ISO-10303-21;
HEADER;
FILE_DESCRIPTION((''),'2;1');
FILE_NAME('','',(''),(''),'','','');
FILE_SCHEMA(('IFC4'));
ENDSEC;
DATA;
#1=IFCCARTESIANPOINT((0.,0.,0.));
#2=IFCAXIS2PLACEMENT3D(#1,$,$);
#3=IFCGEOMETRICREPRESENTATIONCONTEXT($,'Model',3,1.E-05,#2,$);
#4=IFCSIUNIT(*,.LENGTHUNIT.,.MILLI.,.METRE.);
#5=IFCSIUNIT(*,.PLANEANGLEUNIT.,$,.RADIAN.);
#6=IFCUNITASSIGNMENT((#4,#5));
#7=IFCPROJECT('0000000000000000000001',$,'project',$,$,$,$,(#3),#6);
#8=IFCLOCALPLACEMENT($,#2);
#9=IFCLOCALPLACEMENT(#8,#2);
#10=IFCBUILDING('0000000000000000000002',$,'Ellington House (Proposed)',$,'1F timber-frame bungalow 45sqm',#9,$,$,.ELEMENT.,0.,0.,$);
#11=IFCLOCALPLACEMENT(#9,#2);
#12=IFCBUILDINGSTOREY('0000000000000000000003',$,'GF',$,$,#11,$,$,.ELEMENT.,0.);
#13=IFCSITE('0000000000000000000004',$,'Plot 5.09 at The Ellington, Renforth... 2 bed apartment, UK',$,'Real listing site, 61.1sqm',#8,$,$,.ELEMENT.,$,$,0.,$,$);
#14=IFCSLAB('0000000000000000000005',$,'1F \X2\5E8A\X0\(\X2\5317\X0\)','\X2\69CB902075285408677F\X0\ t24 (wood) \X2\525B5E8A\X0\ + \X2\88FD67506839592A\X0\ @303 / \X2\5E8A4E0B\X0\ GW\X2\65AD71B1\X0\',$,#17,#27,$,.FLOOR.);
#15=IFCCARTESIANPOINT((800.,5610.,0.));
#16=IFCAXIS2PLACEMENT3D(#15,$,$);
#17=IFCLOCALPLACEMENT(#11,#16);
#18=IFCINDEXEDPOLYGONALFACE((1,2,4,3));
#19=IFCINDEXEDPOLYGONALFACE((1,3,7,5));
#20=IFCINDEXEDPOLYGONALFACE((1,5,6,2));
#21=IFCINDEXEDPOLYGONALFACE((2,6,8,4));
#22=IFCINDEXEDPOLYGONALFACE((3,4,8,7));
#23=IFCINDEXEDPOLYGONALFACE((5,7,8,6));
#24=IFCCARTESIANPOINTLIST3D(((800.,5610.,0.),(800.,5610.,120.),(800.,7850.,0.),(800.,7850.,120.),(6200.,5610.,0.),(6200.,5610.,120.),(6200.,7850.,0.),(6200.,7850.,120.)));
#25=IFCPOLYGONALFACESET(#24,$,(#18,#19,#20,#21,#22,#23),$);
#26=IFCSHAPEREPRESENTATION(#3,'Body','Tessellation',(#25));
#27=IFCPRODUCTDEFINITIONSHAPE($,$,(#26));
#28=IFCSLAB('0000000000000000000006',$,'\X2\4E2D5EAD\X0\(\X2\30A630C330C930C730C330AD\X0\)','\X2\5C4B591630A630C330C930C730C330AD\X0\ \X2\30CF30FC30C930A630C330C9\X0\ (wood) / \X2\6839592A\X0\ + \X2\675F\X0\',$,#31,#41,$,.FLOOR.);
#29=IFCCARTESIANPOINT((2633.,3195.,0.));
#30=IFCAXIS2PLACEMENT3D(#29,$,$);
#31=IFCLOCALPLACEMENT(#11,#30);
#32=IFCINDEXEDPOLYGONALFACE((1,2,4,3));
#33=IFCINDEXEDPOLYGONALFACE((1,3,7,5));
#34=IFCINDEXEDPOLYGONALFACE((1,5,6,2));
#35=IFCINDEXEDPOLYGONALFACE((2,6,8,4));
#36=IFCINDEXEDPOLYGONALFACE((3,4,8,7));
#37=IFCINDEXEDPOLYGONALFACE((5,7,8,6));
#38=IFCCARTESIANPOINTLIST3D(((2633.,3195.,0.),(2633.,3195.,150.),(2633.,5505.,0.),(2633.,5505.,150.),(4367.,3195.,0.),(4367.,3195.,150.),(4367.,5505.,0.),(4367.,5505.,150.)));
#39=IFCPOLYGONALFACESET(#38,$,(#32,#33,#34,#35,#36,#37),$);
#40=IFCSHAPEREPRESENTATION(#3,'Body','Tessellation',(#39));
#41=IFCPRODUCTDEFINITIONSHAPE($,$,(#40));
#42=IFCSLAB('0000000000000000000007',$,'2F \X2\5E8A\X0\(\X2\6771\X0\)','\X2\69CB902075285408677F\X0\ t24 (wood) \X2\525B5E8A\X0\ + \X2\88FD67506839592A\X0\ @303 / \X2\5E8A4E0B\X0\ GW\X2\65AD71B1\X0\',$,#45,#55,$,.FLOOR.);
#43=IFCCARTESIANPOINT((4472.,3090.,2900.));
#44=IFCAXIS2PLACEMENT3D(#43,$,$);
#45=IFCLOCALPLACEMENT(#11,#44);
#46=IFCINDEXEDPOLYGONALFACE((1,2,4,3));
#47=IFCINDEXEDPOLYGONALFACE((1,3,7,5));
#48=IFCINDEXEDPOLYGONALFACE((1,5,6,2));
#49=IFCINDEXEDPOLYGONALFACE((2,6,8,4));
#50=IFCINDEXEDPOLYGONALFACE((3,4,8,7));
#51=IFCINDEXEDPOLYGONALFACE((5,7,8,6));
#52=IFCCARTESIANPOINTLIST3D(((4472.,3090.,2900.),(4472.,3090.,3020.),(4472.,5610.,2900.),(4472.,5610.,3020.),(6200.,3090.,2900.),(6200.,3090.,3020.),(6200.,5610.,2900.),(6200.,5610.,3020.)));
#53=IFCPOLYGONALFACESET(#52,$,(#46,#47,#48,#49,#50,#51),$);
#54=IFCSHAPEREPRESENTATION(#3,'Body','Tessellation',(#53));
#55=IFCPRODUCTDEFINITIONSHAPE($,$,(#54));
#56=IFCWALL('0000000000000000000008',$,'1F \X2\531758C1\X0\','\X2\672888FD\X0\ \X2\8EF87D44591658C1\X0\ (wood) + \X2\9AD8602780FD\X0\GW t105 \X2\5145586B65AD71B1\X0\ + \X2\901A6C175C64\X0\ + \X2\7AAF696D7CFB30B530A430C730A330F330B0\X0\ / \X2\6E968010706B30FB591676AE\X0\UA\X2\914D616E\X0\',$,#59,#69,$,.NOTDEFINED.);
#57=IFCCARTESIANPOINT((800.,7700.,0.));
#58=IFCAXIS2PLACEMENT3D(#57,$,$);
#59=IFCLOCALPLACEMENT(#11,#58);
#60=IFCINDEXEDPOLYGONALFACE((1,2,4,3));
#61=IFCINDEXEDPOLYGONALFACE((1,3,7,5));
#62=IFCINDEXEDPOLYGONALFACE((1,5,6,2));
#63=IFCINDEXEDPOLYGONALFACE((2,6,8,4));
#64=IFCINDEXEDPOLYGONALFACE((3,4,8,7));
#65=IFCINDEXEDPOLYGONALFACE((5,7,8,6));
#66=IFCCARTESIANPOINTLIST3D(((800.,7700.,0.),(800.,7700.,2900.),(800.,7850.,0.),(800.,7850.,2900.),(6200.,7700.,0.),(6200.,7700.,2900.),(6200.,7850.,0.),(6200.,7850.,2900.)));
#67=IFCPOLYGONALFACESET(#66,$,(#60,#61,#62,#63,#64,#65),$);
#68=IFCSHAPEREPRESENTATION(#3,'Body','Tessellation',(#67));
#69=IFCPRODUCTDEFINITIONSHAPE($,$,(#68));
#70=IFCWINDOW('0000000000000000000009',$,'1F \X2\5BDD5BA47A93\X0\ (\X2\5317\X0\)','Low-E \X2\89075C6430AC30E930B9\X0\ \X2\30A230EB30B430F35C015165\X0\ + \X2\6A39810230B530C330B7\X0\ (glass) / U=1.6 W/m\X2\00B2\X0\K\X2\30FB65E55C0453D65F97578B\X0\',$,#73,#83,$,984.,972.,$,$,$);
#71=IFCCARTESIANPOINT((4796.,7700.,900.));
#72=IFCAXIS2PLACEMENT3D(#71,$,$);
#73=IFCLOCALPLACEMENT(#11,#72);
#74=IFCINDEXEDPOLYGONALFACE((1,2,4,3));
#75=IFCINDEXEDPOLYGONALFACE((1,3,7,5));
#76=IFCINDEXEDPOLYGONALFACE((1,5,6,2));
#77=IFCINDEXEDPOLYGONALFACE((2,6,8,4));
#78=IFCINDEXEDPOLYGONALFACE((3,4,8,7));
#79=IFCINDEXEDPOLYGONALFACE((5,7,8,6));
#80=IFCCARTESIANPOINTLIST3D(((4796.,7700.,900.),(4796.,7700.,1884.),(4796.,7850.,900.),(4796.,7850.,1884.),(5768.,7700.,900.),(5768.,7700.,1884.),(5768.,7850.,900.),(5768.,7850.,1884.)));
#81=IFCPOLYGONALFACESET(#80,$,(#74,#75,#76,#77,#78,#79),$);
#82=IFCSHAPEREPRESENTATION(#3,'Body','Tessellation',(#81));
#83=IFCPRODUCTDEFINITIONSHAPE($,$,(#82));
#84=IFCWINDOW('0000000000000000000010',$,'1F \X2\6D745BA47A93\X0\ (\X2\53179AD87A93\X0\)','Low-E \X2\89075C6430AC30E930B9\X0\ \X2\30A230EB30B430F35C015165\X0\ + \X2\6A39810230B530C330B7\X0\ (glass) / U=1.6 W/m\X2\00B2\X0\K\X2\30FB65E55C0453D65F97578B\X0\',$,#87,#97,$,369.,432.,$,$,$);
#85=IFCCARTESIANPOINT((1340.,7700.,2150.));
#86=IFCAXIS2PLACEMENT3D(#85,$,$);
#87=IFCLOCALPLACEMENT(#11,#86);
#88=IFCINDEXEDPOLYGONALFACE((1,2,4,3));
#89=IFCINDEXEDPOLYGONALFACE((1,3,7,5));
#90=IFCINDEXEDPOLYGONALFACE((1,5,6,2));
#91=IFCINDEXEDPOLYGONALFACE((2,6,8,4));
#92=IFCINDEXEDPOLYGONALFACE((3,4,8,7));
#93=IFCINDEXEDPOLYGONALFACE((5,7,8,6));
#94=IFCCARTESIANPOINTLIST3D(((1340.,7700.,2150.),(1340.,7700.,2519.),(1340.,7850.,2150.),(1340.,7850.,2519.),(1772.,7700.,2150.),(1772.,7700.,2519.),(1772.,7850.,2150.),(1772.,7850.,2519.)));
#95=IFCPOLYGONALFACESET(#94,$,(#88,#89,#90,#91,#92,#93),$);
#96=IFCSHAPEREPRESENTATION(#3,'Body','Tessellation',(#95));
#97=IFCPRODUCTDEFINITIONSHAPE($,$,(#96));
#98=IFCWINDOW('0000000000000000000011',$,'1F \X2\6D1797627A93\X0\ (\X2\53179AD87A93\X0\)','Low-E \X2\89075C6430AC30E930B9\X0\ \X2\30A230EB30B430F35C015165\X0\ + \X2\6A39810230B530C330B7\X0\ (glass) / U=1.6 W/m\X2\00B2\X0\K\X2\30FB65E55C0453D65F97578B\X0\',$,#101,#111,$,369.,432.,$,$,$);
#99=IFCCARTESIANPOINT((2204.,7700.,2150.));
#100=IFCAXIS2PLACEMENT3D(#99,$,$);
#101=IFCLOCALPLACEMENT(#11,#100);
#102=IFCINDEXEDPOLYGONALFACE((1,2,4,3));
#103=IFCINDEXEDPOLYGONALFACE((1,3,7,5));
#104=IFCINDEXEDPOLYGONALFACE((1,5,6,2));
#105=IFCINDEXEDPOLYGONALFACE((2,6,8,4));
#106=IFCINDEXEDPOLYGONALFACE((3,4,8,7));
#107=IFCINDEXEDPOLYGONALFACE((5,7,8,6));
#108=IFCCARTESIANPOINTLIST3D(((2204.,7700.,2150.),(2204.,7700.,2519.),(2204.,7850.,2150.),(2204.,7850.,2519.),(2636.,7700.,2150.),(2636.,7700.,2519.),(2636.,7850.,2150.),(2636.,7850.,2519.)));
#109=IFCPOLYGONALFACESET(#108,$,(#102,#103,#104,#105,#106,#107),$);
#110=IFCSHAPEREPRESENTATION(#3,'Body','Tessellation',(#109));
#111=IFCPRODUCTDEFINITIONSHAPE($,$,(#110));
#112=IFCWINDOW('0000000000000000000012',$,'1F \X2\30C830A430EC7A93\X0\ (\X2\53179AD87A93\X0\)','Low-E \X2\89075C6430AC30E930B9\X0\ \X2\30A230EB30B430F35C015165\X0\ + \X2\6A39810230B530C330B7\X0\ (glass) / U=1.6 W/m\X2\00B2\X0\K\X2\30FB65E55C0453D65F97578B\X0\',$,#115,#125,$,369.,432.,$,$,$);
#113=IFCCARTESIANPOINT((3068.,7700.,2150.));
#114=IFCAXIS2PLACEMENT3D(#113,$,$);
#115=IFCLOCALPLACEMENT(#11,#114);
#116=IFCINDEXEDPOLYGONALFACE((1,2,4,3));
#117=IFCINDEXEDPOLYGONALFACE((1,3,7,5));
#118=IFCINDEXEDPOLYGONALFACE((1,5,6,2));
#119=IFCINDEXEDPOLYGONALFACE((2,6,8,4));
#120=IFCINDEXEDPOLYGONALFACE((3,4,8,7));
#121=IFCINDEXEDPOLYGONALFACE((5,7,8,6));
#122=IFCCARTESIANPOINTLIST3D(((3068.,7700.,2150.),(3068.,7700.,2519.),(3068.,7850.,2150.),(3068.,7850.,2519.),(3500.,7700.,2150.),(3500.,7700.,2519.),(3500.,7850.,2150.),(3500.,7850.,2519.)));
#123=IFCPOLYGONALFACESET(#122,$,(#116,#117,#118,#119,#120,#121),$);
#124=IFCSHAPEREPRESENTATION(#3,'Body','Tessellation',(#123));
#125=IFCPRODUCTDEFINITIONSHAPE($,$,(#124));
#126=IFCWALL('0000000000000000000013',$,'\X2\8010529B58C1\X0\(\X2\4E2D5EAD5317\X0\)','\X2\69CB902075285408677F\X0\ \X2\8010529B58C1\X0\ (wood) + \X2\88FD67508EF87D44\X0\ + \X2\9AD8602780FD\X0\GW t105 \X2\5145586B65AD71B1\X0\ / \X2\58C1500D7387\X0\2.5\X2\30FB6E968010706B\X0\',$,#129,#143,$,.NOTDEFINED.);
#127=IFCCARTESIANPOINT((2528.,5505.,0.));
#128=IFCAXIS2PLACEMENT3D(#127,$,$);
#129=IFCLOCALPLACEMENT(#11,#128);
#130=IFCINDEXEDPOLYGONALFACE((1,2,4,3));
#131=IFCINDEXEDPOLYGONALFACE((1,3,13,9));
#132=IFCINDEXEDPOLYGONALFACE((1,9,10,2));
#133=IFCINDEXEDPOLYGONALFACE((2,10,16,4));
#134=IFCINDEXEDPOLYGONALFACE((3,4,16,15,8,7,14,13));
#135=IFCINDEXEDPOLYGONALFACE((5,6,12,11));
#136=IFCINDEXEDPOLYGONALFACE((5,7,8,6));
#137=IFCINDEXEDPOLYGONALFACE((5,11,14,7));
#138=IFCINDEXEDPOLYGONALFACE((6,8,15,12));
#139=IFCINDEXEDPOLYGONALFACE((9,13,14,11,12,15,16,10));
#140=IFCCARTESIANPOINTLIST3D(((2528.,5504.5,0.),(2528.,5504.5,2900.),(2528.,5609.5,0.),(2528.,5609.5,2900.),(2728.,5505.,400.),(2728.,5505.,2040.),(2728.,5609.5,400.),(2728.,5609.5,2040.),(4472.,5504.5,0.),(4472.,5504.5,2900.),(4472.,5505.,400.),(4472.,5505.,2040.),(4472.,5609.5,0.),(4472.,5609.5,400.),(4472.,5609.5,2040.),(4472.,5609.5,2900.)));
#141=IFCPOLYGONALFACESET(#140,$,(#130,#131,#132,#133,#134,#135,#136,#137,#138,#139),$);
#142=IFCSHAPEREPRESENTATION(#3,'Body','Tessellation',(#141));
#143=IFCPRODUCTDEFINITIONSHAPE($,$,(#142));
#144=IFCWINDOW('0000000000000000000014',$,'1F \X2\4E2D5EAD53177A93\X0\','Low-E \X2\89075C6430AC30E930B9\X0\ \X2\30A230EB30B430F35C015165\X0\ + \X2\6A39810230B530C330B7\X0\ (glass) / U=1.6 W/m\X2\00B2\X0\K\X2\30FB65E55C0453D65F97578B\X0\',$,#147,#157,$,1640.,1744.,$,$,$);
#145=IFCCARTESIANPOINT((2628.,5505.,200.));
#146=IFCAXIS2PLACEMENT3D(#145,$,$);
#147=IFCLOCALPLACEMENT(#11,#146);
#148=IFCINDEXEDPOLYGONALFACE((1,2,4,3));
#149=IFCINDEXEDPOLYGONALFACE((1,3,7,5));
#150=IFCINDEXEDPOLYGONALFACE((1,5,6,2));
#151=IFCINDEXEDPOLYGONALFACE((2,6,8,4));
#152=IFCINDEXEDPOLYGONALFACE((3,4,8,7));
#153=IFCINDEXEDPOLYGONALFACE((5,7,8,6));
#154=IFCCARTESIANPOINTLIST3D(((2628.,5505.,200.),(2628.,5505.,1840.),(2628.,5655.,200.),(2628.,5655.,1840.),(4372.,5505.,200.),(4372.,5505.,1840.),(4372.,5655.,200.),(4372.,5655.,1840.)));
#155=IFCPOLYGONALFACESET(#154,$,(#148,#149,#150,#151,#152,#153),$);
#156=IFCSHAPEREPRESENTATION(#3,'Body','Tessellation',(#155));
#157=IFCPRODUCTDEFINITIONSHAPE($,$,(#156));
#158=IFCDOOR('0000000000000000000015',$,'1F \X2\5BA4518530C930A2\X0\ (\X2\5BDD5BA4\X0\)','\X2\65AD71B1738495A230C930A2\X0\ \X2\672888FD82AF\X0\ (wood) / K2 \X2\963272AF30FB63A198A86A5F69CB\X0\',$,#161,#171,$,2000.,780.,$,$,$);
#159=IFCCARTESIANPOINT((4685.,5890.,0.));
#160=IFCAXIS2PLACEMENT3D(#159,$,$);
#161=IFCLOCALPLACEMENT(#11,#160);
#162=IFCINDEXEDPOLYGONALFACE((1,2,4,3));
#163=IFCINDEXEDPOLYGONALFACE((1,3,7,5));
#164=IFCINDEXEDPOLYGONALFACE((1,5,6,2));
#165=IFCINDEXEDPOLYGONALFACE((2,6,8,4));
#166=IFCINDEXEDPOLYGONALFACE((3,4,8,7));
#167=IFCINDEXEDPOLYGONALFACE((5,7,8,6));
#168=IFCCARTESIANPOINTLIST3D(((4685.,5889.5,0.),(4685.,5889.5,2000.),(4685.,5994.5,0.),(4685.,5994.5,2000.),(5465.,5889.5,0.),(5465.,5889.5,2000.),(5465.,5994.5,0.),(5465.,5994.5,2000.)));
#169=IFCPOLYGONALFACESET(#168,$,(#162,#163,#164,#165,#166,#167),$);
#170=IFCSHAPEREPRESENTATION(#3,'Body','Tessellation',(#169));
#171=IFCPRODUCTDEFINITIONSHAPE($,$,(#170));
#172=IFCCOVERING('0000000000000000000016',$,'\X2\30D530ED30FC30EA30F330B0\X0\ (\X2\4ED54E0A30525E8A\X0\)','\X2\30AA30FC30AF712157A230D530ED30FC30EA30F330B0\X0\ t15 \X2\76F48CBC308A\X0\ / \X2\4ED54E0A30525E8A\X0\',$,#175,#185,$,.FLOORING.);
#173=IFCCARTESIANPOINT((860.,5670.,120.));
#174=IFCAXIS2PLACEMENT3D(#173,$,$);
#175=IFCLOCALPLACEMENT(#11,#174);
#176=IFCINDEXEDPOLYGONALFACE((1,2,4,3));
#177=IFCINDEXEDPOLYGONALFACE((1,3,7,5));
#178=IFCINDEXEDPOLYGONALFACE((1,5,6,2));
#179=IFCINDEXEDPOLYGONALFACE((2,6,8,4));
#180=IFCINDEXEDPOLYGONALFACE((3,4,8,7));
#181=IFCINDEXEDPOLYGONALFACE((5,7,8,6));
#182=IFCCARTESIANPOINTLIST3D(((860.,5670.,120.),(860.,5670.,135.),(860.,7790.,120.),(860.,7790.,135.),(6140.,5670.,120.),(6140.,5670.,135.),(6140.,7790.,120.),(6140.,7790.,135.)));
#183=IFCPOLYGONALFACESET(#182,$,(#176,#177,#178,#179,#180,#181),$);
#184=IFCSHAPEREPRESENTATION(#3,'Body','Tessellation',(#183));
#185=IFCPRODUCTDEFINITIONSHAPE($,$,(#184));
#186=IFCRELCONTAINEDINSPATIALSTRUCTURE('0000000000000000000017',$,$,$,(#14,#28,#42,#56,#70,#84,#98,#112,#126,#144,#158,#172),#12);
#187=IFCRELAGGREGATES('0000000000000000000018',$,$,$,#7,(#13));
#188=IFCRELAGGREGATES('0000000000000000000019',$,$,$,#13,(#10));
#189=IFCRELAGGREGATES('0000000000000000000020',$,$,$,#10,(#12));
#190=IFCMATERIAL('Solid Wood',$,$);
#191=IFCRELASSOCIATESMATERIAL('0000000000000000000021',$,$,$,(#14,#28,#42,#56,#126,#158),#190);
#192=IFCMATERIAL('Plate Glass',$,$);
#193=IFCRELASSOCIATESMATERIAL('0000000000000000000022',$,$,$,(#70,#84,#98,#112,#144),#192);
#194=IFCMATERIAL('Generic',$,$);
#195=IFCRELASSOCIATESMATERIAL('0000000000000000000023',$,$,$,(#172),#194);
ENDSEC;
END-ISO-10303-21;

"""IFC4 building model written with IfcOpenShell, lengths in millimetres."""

from ifc_helpers import new_model, si_unit, frame, frame_2d, origin, place, context, project, spatial, rectangle, extrude, material, element, fill, save


model = new_model("IFC4")

# Units and contexts
model_context = context("Model", 3, precision=1e-05, world=origin())
ifc_project = project(units=[si_unit("LENGTHUNIT", "METRE", prefix="MILLI"), si_unit("PLANEANGLEUNIT", "RADIAN")], contexts=[model_context])

# Site, building, storey
site_placement = place(None, origin())
site = spatial("IfcSite", under=ifc_project, at=site_placement, Name="Plot 5.09 at The Ellington, Renforth... 2 bed apartment, UK", ObjectType="Real listing site, 61.1sqm", CompositionType="ELEMENT", RefElevation=0.0)
building_placement = place(site_placement, origin())
building = spatial("IfcBuilding", under=site, at=building_placement, Name="Ellington House (Proposed)", ObjectType="1F timber-frame bungalow 45sqm", CompositionType="ELEMENT", ElevationOfRefHeight=0.0, ElevationOfTerrain=0.0)
storey_placement = place(building_placement, origin())
storey = spatial("IfcBuildingStorey", under=building, at=storey_placement, Name="GF", CompositionType="ELEMENT", Elevation=0.0)

# Slabs
ifc_material_1 = material(Name="Solid Wood")
slab_1_placement = place(storey_placement, frame((800.0, 5610.0, 0.0)))
element("IfcSlab", 1, at=slab_1_placement, inside=storey, material=ifc_material_1, Name="1F 床(北)", Description="構造用合板 t24 (wood) 剛床 + 製材根太 @303 / 床下 GW断熱", PredefinedType="FLOOR", context=model_context, shape_type="SweptSolid", body=[
    extrude(rectangle(XDim=5400.0, YDim=2240.0, at=frame_2d((2700.0, 1120.0))), frame((800.0, 5610.0, 0.0)), (0.0, 0.0, 1.0), 120.0),
])
slab_2_placement = place(storey_placement, frame((2633.0, 3195.0, 0.0)))
element("IfcSlab", 2, at=slab_2_placement, inside=storey, material=ifc_material_1, Name="中庭(ウッドデッキ)", Description="屋外ウッドデッキ ハードウッド (wood) / 根太 + 束", PredefinedType="FLOOR", context=model_context, shape_type="SweptSolid", body=[
    extrude(rectangle(XDim=1734.0, YDim=2310.0, at=frame_2d((867.0, 1155.0))), frame((2633.0, 3195.0, 0.0)), (0.0, 0.0, 1.0), 150.0),
])
slab_3_placement = place(storey_placement, frame((4472.0, 3090.0, 2900.0)))
element("IfcSlab", 3, at=slab_3_placement, inside=storey, material=ifc_material_1, Name="2F 床(東)", Description="構造用合板 t24 (wood) 剛床 + 製材根太 @303 / 床下 GW断熱", PredefinedType="FLOOR", context=model_context, shape_type="SweptSolid", body=[
    extrude(rectangle(XDim=1728.0, YDim=2520.0, at=frame_2d((864.0, 1260.0))), frame((4472.0, 3090.0, 2900.0)), (0.0, 0.0, 1.0), 120.0),
])

# Wall, openings, windows
wall_1_placement = place(storey_placement, frame((800.0, 7700.0, 0.0)))
wall_1 = element("IfcWall", 4, at=wall_1_placement, inside=storey, material=ifc_material_1, Name="1F 北壁", Description="木製 軸組外壁 (wood) + 高性能GW t105 充填断熱 + 通気層 + 窯業系サイディング / 準耐火・外皮UA配慮", PredefinedType="NOTDEFINED", context=model_context, shape_type="SweptSolid", body=[
    extrude(rectangle(XDim=5400.0, YDim=150.0, at=frame_2d((2700.0, 75.0))), frame((800.0, 7700.0, 0.0)), (0.0, 0.0, 1.0), 2900.0),
])
opening_1_placement = place(storey_placement, frame((4796.0, 7700.0, 900.0)))
opening_1 = element("IfcOpeningElement", 5, at=opening_1_placement, cuts=wall_1, PredefinedType="NOTDEFINED", context=model_context, shape_type="SweptSolid", body=[
    extrude(rectangle(XDim=972.0, YDim=150.0, at=frame_2d((486.0, 75.0))), frame((4796.0, 7700.0, 900.0)), (0.0, 0.0, 1.0), 984.0),
])
opening_2_placement = place(storey_placement, frame((1340.0, 7700.0, 2150.0)))
opening_2 = element("IfcOpeningElement", 6, at=opening_2_placement, cuts=wall_1, PredefinedType="NOTDEFINED", context=model_context, shape_type="SweptSolid", body=[
    extrude(rectangle(XDim=432.0, YDim=150.0, at=frame_2d((216.0, 75.0))), frame((1340.0, 7700.0, 2150.0)), (0.0, 0.0, 1.0), 369.0),
])
opening_3_placement = place(storey_placement, frame((2204.0, 7700.0, 2150.0)))
opening_3 = element("IfcOpeningElement", 7, at=opening_3_placement, cuts=wall_1, PredefinedType="NOTDEFINED", context=model_context, shape_type="SweptSolid", body=[
    extrude(rectangle(XDim=432.0, YDim=150.0, at=frame_2d((216.0, 75.0))), frame((2204.0, 7700.0, 2150.0)), (0.0, 0.0, 1.0), 369.0),
])
opening_4_placement = place(storey_placement, frame((3068.0, 7700.0, 2150.0)))
opening_4 = element("IfcOpeningElement", 8, at=opening_4_placement, cuts=wall_1, PredefinedType="NOTDEFINED", context=model_context, shape_type="SweptSolid", body=[
    extrude(rectangle(XDim=432.0, YDim=150.0, at=frame_2d((216.0, 75.0))), frame((3068.0, 7700.0, 2150.0)), (0.0, 0.0, 1.0), 369.0),
])
ifc_material_2 = material(Name="Plate Glass")
window_1_placement = place(storey_placement, frame((4796.0, 7700.0, 900.0)))
window_1 = element("IfcWindow", 9, at=window_1_placement, inside=storey, material=ifc_material_2, Name="1F 寝室窓 (北)", Description="Low-E 複層ガラス アルゴン封入 + 樹脂サッシ (glass) / U=1.6 W/m²K・日射取得型", OverallHeight=984.0, OverallWidth=972.0, context=model_context, shape_type="SweptSolid", body=[
    extrude(rectangle(XDim=972.0, YDim=150.0, at=frame_2d((486.0, 75.0))), frame((4796.0, 7700.0, 900.0)), (0.0, 0.0, 1.0), 984.0),
])
fill(opening_1, window_1)
window_2_placement = place(storey_placement, frame((1340.0, 7700.0, 2150.0)))
window_2 = element("IfcWindow", 10, at=window_2_placement, inside=storey, material=ifc_material_2, Name="1F 浴室窓 (北高窓)", Description="Low-E 複層ガラス アルゴン封入 + 樹脂サッシ (glass) / U=1.6 W/m²K・日射取得型", OverallHeight=369.0, OverallWidth=432.0, context=model_context, shape_type="SweptSolid", body=[
    extrude(rectangle(XDim=432.0, YDim=150.0, at=frame_2d((216.0, 75.0))), frame((1340.0, 7700.0, 2150.0)), (0.0, 0.0, 1.0), 369.0),
])
fill(opening_2, window_2)
window_3_placement = place(storey_placement, frame((2204.0, 7700.0, 2150.0)))
window_3 = element("IfcWindow", 11, at=window_3_placement, inside=storey, material=ifc_material_2, Name="1F 洗面窓 (北高窓)", Description="Low-E 複層ガラス アルゴン封入 + 樹脂サッシ (glass) / U=1.6 W/m²K・日射取得型", OverallHeight=369.0, OverallWidth=432.0, context=model_context, shape_type="SweptSolid", body=[
    extrude(rectangle(XDim=432.0, YDim=150.0, at=frame_2d((216.0, 75.0))), frame((2204.0, 7700.0, 2150.0)), (0.0, 0.0, 1.0), 369.0),
])
fill(opening_3, window_3)
window_4_placement = place(storey_placement, frame((3068.0, 7700.0, 2150.0)))
window_4 = element("IfcWindow", 12, at=window_4_placement, inside=storey, material=ifc_material_2, Name="1F トイレ窓 (北高窓)", Description="Low-E 複層ガラス アルゴン封入 + 樹脂サッシ (glass) / U=1.6 W/m²K・日射取得型", OverallHeight=369.0, OverallWidth=432.0, context=model_context, shape_type="SweptSolid", body=[
    extrude(rectangle(XDim=432.0, YDim=150.0, at=frame_2d((216.0, 75.0))), frame((3068.0, 7700.0, 2150.0)), (0.0, 0.0, 1.0), 369.0),
])
fill(opening_4, window_4)

# Wall, opening, window
wall_2_placement = place(storey_placement, frame((2528.0, 5505.0, 0.0)))
wall_2 = element("IfcWall", 13, at=wall_2_placement, inside=storey, material=ifc_material_1, Name="耐力壁(中庭北)", Description="構造用合板 耐力壁 (wood) + 製材軸組 + 高性能GW t105 充填断熱 / 壁倍率2.5・準耐火", PredefinedType="NOTDEFINED", context=model_context, shape_type="SweptSolid", body=[
    extrude(rectangle(XDim=1944.0, YDim=105.0, at=frame_2d((972.0, 52.0))), frame((2528.0, 5505.0, 0.0)), (0.0, 0.0, 1.0), 2900.0),
])
opening_5_placement = place(storey_placement, frame((2628.0, 5505.0, 200.0)))
opening_5 = element("IfcOpeningElement", 14, at=opening_5_placement, cuts=wall_2, PredefinedType="NOTDEFINED", context=model_context, shape_type="SweptSolid", body=[
    extrude(rectangle(XDim=1744.0, YDim=150.0, at=frame_2d((872.0, 75.0))), frame((2628.0, 5505.0, 200.0)), (0.0, 0.0, 1.0), 1640.0),
])
window_5_placement = place(storey_placement, frame((2628.0, 5505.0, 200.0)))
window_5 = element("IfcWindow", 15, at=window_5_placement, inside=storey, material=ifc_material_2, Name="1F 中庭北窓", Description="Low-E 複層ガラス アルゴン封入 + 樹脂サッシ (glass) / U=1.6 W/m²K・日射取得型", OverallHeight=1640.0, OverallWidth=1744.0, context=model_context, shape_type="SweptSolid", body=[
    extrude(rectangle(XDim=1744.0, YDim=150.0, at=frame_2d((872.0, 75.0))), frame((2628.0, 5505.0, 200.0)), (0.0, 0.0, 1.0), 1640.0),
])
fill(opening_5, window_5)

# Door
door_1_placement = place(storey_placement, frame((4685.0, 5890.0, 0.0)))
element("IfcDoor", 16, at=door_1_placement, inside=storey, material=ifc_material_1, Name="1F 室内ドア (寝室)", Description="断熱玄関ドア 木製芯 (wood) / K2 防犯・採風機構", OverallHeight=2000.0, OverallWidth=780.0, context=model_context, shape_type="SweptSolid", body=[
    extrude(rectangle(XDim=780.0, YDim=105.0, at=frame_2d((390.0, 52.0))), frame((4685.0, 5890.0, 0.0)), (0.0, 0.0, 1.0), 2000.0),
])

# Covering
ifc_material_3 = material(Name="Generic")
covering_1_placement = place(storey_placement, frame((860.0, 5670.0, 120.0)))
element("IfcCovering", 17, at=covering_1_placement, inside=storey, material=ifc_material_3, Name="フローリング (仕上げ床)", Description="オーク無垢フローリング t15 直貼り / 仕上げ床", PredefinedType="FLOORING", context=model_context, shape_type="SweptSolid", body=[
    extrude(rectangle(XDim=5280.0, YDim=2120.0, at=frame_2d((2640.0, 1060.0))), frame((860.0, 5670.0, 120.0)), (0.0, 0.0, 1.0), 15.0),
])

save(model, "model.ifc")
